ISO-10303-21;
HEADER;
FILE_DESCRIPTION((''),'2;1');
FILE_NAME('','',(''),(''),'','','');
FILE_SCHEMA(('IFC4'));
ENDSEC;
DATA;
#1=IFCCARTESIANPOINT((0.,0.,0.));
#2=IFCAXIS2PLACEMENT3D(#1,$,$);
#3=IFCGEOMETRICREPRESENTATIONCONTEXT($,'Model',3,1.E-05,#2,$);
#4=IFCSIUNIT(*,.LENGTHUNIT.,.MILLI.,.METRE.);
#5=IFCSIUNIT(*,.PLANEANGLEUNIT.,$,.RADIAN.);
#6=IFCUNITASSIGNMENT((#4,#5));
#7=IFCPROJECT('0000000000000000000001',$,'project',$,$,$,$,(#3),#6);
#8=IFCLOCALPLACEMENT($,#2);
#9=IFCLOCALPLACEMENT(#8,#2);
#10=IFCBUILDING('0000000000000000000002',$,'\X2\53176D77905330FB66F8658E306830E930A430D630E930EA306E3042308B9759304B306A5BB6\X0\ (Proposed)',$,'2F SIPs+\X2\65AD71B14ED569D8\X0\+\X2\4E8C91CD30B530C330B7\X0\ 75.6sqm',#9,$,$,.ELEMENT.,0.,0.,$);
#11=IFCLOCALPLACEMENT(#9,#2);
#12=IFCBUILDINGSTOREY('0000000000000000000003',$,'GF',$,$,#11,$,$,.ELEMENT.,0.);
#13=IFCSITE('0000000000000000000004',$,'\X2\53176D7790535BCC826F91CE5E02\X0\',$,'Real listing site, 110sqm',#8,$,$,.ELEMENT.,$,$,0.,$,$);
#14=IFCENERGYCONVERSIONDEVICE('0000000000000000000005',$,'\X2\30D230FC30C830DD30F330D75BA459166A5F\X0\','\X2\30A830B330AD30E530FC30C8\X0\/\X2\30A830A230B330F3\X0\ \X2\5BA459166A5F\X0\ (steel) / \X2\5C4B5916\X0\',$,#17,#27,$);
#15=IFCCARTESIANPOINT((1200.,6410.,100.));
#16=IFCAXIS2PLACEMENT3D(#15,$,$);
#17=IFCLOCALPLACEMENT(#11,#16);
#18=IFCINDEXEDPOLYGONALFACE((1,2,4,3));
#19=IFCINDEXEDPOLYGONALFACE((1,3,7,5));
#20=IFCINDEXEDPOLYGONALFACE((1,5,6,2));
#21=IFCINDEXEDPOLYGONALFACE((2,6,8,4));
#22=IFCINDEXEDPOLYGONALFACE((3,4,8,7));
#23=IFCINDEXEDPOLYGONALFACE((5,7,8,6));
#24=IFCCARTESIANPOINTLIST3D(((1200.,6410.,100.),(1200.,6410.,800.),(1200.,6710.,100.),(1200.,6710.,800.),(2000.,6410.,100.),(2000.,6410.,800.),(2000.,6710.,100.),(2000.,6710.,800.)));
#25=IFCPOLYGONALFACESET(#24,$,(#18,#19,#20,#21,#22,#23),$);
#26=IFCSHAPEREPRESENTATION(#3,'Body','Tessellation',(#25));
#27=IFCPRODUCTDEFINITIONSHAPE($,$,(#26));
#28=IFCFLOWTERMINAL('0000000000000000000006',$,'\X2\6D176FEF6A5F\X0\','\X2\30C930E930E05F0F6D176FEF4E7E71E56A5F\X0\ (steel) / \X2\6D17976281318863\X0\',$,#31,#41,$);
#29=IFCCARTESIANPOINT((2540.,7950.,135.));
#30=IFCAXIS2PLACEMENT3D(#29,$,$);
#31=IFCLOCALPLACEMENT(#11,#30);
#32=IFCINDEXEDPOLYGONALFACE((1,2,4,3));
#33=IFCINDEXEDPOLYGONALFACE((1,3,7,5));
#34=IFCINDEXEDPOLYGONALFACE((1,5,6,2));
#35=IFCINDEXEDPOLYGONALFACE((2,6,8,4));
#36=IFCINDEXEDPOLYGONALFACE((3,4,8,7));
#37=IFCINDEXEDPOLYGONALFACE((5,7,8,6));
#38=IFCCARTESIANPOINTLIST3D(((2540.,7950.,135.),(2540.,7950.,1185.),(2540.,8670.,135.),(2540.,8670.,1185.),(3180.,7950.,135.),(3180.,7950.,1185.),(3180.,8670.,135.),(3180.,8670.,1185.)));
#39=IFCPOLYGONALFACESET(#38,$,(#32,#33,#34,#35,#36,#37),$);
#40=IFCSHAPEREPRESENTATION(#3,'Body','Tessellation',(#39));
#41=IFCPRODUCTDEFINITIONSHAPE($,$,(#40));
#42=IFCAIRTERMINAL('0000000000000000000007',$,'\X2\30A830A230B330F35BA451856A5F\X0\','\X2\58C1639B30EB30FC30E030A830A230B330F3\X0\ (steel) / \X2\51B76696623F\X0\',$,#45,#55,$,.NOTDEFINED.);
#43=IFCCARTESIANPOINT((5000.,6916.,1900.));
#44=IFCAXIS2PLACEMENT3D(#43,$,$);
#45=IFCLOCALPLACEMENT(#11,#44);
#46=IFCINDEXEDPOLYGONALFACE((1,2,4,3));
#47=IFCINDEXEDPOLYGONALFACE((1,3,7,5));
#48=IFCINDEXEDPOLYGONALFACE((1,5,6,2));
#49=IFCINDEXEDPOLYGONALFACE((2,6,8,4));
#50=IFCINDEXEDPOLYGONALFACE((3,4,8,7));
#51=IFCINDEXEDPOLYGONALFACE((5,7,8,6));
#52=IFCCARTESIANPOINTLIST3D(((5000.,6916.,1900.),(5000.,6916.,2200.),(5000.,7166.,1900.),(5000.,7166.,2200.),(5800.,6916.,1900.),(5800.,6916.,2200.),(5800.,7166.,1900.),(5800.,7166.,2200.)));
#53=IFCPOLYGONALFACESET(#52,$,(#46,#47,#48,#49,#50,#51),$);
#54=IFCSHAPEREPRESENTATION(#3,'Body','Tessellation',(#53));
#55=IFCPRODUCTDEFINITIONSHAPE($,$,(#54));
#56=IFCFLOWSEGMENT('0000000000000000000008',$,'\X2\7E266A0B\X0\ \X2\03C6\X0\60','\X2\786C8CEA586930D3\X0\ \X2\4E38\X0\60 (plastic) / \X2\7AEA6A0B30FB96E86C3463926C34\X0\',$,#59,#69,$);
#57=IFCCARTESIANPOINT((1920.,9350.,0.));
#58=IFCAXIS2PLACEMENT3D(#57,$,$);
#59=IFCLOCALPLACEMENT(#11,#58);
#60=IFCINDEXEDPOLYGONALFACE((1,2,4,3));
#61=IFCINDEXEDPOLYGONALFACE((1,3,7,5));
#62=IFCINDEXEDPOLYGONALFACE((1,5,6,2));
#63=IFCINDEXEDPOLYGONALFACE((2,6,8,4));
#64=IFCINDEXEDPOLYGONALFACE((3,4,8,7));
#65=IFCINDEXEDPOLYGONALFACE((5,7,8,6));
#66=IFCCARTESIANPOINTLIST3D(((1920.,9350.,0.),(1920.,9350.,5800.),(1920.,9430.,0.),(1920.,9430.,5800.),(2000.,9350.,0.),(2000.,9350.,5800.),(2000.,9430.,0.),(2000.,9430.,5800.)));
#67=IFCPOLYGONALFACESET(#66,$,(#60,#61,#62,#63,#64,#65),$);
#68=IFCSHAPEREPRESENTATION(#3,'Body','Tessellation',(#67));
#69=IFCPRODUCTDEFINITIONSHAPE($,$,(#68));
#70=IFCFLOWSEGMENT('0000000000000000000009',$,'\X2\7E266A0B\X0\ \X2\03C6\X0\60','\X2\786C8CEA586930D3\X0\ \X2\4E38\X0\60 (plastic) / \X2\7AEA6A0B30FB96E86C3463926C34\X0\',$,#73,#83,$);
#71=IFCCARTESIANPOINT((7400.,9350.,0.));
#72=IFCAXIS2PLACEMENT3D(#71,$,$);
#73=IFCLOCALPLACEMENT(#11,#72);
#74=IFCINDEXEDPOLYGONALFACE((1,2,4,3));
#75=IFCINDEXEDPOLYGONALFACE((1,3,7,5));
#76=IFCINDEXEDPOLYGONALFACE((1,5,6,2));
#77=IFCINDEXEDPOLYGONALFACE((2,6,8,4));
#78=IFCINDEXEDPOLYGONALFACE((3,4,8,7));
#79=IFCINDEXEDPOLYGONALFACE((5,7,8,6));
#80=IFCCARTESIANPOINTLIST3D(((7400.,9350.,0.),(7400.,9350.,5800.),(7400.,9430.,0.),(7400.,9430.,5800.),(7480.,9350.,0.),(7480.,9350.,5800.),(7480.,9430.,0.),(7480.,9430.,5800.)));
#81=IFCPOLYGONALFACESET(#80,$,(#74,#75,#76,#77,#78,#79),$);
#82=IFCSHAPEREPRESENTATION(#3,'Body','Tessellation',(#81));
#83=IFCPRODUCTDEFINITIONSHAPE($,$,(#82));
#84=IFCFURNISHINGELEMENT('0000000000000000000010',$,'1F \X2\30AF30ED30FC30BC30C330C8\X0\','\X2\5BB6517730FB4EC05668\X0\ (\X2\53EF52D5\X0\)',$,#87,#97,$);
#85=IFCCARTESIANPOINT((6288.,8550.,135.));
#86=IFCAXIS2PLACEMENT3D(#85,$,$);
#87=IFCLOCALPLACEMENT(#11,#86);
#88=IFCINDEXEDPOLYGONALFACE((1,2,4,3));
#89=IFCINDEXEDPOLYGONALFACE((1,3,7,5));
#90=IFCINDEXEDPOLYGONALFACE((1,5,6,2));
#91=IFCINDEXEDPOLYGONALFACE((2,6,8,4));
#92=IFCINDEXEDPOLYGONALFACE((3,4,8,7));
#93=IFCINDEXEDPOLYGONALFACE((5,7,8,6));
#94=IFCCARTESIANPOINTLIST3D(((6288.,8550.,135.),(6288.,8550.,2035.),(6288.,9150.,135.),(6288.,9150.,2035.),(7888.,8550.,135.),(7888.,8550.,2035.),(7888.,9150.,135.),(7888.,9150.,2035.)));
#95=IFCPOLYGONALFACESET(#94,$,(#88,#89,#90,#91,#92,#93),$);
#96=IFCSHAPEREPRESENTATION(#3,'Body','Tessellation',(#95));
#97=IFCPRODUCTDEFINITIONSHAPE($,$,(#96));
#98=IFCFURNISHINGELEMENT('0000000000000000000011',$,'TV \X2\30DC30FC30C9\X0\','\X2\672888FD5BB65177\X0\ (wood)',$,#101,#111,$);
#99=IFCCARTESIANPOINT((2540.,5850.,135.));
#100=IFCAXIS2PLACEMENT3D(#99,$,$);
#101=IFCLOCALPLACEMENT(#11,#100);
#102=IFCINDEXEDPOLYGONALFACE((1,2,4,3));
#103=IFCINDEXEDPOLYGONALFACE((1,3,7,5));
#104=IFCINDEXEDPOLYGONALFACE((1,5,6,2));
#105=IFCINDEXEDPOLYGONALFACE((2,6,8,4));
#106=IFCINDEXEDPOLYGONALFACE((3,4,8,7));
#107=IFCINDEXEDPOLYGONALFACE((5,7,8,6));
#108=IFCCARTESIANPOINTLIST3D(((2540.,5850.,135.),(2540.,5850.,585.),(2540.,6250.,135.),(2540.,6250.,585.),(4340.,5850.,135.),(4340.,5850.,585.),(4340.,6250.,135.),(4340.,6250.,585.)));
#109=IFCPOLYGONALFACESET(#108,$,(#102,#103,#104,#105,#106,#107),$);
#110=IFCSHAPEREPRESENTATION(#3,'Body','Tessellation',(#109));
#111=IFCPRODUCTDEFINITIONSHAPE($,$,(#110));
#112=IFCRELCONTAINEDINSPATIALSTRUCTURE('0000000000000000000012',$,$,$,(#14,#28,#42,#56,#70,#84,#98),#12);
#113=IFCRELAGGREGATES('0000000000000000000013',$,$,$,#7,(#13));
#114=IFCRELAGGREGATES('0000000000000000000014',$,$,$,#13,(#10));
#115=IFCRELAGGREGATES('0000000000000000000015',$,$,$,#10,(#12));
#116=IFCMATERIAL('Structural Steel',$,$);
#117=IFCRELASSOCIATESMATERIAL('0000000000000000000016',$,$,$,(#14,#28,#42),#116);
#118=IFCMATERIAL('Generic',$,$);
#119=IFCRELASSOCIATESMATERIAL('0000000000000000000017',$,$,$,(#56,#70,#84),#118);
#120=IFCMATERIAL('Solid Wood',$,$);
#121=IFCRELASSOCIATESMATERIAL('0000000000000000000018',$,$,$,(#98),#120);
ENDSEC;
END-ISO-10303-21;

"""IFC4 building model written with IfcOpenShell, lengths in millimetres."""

from ifc_helpers import new_model, si_unit, frame, frame_2d, origin, place, context, project, spatial, rectangle, extrude, material, element, save


model = new_model("IFC4")

# Units and contexts
model_context = context("Model", 3, precision=1e-05, world=origin())
ifc_project = project(units=[si_unit("LENGTHUNIT", "METRE", prefix="MILLI"), si_unit("PLANEANGLEUNIT", "RADIAN")], contexts=[model_context])

# Site, building, storey
site_placement = place(None, origin())
site = spatial("IfcSite", under=ifc_project, at=site_placement, Name="北海道富良野市", ObjectType="Real listing site, 110sqm", CompositionType="ELEMENT", RefElevation=0.0)
building_placement = place(site_placement, origin())
building = spatial("IfcBuilding", under=site, at=building_placement, Name="北海道・書斎とライブラリのある静かな家 (Proposed)", ObjectType="2F SIPs+断熱仕様+二重サッシ 75.6sqm", CompositionType="ELEMENT", ElevationOfRefHeight=0.0, ElevationOfTerrain=0.0)
storey_placement = place(building_placement, origin())
storey = spatial("IfcBuildingStorey", under=building, at=storey_placement, Name="GF", CompositionType="ELEMENT", Elevation=0.0)

# Shared definitions
ifc_material_1 = material(Name="Solid Wood")

# Shared definitions
ifc_material_2 = material(Name="Generic")

# Shared definitions
ifc_material_3 = material(Name="Structural Steel")

# Energy conversion device
energy_conversion_device_placement = place(storey_placement, frame((1200.0, 6410.0, 100.0)))
element("IfcEnergyConversionDevice", 1, at=energy_conversion_device_placement, inside=storey, material=ifc_material_3, Name="ヒートポンプ室外機", Description="エコキュート/エアコン 室外機 (steel) / 屋外", context=model_context, shape_type="SweptSolid", body=[
    extrude(rectangle(XDim=800.0, YDim=300.0, at=frame_2d((400.0, 150.0))), frame((1200.0, 6410.0, 100.0)), (0.0, 0.0, 1.0), 700.0),
])

# Flow terminal
flow_terminal_placement = place(storey_placement, frame((2540.0, 7950.0, 135.0)))
element("IfcFlowTerminal", 2, at=flow_terminal_placement, inside=storey, material=ifc_material_3, Name="洗濯機", Description="ドラム式洗濯乾燥機 (steel) / 洗面脱衣", context=model_context, shape_type="SweptSolid", body=[
    extrude(rectangle(XDim=640.0, YDim=720.0, at=frame_2d((320.0, 360.0))), frame((2540.0, 7950.0, 135.0)), (0.0, 0.0, 1.0), 1050.0),
])

# Air terminal
air_terminal_placement = place(storey_placement, frame((5000.0, 6916.0, 1900.0)))
element("IfcAirTerminal", 3, at=air_terminal_placement, inside=storey, material=ifc_material_3, Name="エアコン室内機", Description="壁掛ルームエアコン (steel) / 冷暖房", PredefinedType="NOTDEFINED", context=model_context, shape_type="SweptSolid", body=[
    extrude(rectangle(XDim=800.0, YDim=250.0, at=frame_2d((400.0, 125.0))), frame((5000.0, 6916.0, 1900.0)), (0.0, 0.0, 1.0), 300.0),
])

# Flow segments
flow_segment_1_placement = place(storey_placement, frame((1920.0, 9350.0, 0.0)))
element("IfcFlowSegment", 4, at=flow_segment_1_placement, inside=storey, material=ifc_material_2, Name="縦樋 φ60", Description="硬質塩ビ 丸60 (plastic) / 竪樋・雨水排水", context=model_context, shape_type="SweptSolid", body=[
    extrude(rectangle(XDim=80.0, YDim=80.0, at=frame_2d((40.0, 40.0))), frame((1920.0, 9350.0, 0.0)), (0.0, 0.0, 1.0), 5800.0),
])
flow_segment_2_placement = place(storey_placement, frame((7400.0, 9350.0, 0.0)))
element("IfcFlowSegment", 5, at=flow_segment_2_placement, inside=storey, material=ifc_material_2, Name="縦樋 φ60", Description="硬質塩ビ 丸60 (plastic) / 竪樋・雨水排水", context=model_context, shape_type="SweptSolid", body=[
    extrude(rectangle(XDim=80.0, YDim=80.0, at=frame_2d((40.0, 40.0))), frame((7400.0, 9350.0, 0.0)), (0.0, 0.0, 1.0), 5800.0),
])

# Furnishing elements
furnishing_1_placement = place(storey_placement, frame((6288.0, 8550.0, 135.0)))
element("IfcFurnishingElement", 6, at=furnishing_1_placement, inside=storey, material=ifc_material_2, Name="1F クローゼット", Description="家具・什器 (可動)", context=model_context, shape_type="SweptSolid", body=[
    extrude(rectangle(XDim=1600.0, YDim=600.0, at=frame_2d((800.0, 300.0))), frame((6288.0, 8550.0, 135.0)), (0.0, 0.0, 1.0), 1900.0),
])
furnishing_2_placement = place(storey_placement, frame((2540.0, 5850.0, 135.0)))
element("IfcFurnishingElement", 7, at=furnishing_2_placement, inside=storey, material=ifc_material_1, Name="TV ボード", Description="木製家具 (wood)", context=model_context, shape_type="SweptSolid", body=[
    extrude(rectangle(XDim=1800.0, YDim=400.0, at=frame_2d((900.0, 200.0))), frame((2540.0, 5850.0, 135.0)), (0.0, 0.0, 1.0), 450.0),
])

save(model, "model.ifc")
